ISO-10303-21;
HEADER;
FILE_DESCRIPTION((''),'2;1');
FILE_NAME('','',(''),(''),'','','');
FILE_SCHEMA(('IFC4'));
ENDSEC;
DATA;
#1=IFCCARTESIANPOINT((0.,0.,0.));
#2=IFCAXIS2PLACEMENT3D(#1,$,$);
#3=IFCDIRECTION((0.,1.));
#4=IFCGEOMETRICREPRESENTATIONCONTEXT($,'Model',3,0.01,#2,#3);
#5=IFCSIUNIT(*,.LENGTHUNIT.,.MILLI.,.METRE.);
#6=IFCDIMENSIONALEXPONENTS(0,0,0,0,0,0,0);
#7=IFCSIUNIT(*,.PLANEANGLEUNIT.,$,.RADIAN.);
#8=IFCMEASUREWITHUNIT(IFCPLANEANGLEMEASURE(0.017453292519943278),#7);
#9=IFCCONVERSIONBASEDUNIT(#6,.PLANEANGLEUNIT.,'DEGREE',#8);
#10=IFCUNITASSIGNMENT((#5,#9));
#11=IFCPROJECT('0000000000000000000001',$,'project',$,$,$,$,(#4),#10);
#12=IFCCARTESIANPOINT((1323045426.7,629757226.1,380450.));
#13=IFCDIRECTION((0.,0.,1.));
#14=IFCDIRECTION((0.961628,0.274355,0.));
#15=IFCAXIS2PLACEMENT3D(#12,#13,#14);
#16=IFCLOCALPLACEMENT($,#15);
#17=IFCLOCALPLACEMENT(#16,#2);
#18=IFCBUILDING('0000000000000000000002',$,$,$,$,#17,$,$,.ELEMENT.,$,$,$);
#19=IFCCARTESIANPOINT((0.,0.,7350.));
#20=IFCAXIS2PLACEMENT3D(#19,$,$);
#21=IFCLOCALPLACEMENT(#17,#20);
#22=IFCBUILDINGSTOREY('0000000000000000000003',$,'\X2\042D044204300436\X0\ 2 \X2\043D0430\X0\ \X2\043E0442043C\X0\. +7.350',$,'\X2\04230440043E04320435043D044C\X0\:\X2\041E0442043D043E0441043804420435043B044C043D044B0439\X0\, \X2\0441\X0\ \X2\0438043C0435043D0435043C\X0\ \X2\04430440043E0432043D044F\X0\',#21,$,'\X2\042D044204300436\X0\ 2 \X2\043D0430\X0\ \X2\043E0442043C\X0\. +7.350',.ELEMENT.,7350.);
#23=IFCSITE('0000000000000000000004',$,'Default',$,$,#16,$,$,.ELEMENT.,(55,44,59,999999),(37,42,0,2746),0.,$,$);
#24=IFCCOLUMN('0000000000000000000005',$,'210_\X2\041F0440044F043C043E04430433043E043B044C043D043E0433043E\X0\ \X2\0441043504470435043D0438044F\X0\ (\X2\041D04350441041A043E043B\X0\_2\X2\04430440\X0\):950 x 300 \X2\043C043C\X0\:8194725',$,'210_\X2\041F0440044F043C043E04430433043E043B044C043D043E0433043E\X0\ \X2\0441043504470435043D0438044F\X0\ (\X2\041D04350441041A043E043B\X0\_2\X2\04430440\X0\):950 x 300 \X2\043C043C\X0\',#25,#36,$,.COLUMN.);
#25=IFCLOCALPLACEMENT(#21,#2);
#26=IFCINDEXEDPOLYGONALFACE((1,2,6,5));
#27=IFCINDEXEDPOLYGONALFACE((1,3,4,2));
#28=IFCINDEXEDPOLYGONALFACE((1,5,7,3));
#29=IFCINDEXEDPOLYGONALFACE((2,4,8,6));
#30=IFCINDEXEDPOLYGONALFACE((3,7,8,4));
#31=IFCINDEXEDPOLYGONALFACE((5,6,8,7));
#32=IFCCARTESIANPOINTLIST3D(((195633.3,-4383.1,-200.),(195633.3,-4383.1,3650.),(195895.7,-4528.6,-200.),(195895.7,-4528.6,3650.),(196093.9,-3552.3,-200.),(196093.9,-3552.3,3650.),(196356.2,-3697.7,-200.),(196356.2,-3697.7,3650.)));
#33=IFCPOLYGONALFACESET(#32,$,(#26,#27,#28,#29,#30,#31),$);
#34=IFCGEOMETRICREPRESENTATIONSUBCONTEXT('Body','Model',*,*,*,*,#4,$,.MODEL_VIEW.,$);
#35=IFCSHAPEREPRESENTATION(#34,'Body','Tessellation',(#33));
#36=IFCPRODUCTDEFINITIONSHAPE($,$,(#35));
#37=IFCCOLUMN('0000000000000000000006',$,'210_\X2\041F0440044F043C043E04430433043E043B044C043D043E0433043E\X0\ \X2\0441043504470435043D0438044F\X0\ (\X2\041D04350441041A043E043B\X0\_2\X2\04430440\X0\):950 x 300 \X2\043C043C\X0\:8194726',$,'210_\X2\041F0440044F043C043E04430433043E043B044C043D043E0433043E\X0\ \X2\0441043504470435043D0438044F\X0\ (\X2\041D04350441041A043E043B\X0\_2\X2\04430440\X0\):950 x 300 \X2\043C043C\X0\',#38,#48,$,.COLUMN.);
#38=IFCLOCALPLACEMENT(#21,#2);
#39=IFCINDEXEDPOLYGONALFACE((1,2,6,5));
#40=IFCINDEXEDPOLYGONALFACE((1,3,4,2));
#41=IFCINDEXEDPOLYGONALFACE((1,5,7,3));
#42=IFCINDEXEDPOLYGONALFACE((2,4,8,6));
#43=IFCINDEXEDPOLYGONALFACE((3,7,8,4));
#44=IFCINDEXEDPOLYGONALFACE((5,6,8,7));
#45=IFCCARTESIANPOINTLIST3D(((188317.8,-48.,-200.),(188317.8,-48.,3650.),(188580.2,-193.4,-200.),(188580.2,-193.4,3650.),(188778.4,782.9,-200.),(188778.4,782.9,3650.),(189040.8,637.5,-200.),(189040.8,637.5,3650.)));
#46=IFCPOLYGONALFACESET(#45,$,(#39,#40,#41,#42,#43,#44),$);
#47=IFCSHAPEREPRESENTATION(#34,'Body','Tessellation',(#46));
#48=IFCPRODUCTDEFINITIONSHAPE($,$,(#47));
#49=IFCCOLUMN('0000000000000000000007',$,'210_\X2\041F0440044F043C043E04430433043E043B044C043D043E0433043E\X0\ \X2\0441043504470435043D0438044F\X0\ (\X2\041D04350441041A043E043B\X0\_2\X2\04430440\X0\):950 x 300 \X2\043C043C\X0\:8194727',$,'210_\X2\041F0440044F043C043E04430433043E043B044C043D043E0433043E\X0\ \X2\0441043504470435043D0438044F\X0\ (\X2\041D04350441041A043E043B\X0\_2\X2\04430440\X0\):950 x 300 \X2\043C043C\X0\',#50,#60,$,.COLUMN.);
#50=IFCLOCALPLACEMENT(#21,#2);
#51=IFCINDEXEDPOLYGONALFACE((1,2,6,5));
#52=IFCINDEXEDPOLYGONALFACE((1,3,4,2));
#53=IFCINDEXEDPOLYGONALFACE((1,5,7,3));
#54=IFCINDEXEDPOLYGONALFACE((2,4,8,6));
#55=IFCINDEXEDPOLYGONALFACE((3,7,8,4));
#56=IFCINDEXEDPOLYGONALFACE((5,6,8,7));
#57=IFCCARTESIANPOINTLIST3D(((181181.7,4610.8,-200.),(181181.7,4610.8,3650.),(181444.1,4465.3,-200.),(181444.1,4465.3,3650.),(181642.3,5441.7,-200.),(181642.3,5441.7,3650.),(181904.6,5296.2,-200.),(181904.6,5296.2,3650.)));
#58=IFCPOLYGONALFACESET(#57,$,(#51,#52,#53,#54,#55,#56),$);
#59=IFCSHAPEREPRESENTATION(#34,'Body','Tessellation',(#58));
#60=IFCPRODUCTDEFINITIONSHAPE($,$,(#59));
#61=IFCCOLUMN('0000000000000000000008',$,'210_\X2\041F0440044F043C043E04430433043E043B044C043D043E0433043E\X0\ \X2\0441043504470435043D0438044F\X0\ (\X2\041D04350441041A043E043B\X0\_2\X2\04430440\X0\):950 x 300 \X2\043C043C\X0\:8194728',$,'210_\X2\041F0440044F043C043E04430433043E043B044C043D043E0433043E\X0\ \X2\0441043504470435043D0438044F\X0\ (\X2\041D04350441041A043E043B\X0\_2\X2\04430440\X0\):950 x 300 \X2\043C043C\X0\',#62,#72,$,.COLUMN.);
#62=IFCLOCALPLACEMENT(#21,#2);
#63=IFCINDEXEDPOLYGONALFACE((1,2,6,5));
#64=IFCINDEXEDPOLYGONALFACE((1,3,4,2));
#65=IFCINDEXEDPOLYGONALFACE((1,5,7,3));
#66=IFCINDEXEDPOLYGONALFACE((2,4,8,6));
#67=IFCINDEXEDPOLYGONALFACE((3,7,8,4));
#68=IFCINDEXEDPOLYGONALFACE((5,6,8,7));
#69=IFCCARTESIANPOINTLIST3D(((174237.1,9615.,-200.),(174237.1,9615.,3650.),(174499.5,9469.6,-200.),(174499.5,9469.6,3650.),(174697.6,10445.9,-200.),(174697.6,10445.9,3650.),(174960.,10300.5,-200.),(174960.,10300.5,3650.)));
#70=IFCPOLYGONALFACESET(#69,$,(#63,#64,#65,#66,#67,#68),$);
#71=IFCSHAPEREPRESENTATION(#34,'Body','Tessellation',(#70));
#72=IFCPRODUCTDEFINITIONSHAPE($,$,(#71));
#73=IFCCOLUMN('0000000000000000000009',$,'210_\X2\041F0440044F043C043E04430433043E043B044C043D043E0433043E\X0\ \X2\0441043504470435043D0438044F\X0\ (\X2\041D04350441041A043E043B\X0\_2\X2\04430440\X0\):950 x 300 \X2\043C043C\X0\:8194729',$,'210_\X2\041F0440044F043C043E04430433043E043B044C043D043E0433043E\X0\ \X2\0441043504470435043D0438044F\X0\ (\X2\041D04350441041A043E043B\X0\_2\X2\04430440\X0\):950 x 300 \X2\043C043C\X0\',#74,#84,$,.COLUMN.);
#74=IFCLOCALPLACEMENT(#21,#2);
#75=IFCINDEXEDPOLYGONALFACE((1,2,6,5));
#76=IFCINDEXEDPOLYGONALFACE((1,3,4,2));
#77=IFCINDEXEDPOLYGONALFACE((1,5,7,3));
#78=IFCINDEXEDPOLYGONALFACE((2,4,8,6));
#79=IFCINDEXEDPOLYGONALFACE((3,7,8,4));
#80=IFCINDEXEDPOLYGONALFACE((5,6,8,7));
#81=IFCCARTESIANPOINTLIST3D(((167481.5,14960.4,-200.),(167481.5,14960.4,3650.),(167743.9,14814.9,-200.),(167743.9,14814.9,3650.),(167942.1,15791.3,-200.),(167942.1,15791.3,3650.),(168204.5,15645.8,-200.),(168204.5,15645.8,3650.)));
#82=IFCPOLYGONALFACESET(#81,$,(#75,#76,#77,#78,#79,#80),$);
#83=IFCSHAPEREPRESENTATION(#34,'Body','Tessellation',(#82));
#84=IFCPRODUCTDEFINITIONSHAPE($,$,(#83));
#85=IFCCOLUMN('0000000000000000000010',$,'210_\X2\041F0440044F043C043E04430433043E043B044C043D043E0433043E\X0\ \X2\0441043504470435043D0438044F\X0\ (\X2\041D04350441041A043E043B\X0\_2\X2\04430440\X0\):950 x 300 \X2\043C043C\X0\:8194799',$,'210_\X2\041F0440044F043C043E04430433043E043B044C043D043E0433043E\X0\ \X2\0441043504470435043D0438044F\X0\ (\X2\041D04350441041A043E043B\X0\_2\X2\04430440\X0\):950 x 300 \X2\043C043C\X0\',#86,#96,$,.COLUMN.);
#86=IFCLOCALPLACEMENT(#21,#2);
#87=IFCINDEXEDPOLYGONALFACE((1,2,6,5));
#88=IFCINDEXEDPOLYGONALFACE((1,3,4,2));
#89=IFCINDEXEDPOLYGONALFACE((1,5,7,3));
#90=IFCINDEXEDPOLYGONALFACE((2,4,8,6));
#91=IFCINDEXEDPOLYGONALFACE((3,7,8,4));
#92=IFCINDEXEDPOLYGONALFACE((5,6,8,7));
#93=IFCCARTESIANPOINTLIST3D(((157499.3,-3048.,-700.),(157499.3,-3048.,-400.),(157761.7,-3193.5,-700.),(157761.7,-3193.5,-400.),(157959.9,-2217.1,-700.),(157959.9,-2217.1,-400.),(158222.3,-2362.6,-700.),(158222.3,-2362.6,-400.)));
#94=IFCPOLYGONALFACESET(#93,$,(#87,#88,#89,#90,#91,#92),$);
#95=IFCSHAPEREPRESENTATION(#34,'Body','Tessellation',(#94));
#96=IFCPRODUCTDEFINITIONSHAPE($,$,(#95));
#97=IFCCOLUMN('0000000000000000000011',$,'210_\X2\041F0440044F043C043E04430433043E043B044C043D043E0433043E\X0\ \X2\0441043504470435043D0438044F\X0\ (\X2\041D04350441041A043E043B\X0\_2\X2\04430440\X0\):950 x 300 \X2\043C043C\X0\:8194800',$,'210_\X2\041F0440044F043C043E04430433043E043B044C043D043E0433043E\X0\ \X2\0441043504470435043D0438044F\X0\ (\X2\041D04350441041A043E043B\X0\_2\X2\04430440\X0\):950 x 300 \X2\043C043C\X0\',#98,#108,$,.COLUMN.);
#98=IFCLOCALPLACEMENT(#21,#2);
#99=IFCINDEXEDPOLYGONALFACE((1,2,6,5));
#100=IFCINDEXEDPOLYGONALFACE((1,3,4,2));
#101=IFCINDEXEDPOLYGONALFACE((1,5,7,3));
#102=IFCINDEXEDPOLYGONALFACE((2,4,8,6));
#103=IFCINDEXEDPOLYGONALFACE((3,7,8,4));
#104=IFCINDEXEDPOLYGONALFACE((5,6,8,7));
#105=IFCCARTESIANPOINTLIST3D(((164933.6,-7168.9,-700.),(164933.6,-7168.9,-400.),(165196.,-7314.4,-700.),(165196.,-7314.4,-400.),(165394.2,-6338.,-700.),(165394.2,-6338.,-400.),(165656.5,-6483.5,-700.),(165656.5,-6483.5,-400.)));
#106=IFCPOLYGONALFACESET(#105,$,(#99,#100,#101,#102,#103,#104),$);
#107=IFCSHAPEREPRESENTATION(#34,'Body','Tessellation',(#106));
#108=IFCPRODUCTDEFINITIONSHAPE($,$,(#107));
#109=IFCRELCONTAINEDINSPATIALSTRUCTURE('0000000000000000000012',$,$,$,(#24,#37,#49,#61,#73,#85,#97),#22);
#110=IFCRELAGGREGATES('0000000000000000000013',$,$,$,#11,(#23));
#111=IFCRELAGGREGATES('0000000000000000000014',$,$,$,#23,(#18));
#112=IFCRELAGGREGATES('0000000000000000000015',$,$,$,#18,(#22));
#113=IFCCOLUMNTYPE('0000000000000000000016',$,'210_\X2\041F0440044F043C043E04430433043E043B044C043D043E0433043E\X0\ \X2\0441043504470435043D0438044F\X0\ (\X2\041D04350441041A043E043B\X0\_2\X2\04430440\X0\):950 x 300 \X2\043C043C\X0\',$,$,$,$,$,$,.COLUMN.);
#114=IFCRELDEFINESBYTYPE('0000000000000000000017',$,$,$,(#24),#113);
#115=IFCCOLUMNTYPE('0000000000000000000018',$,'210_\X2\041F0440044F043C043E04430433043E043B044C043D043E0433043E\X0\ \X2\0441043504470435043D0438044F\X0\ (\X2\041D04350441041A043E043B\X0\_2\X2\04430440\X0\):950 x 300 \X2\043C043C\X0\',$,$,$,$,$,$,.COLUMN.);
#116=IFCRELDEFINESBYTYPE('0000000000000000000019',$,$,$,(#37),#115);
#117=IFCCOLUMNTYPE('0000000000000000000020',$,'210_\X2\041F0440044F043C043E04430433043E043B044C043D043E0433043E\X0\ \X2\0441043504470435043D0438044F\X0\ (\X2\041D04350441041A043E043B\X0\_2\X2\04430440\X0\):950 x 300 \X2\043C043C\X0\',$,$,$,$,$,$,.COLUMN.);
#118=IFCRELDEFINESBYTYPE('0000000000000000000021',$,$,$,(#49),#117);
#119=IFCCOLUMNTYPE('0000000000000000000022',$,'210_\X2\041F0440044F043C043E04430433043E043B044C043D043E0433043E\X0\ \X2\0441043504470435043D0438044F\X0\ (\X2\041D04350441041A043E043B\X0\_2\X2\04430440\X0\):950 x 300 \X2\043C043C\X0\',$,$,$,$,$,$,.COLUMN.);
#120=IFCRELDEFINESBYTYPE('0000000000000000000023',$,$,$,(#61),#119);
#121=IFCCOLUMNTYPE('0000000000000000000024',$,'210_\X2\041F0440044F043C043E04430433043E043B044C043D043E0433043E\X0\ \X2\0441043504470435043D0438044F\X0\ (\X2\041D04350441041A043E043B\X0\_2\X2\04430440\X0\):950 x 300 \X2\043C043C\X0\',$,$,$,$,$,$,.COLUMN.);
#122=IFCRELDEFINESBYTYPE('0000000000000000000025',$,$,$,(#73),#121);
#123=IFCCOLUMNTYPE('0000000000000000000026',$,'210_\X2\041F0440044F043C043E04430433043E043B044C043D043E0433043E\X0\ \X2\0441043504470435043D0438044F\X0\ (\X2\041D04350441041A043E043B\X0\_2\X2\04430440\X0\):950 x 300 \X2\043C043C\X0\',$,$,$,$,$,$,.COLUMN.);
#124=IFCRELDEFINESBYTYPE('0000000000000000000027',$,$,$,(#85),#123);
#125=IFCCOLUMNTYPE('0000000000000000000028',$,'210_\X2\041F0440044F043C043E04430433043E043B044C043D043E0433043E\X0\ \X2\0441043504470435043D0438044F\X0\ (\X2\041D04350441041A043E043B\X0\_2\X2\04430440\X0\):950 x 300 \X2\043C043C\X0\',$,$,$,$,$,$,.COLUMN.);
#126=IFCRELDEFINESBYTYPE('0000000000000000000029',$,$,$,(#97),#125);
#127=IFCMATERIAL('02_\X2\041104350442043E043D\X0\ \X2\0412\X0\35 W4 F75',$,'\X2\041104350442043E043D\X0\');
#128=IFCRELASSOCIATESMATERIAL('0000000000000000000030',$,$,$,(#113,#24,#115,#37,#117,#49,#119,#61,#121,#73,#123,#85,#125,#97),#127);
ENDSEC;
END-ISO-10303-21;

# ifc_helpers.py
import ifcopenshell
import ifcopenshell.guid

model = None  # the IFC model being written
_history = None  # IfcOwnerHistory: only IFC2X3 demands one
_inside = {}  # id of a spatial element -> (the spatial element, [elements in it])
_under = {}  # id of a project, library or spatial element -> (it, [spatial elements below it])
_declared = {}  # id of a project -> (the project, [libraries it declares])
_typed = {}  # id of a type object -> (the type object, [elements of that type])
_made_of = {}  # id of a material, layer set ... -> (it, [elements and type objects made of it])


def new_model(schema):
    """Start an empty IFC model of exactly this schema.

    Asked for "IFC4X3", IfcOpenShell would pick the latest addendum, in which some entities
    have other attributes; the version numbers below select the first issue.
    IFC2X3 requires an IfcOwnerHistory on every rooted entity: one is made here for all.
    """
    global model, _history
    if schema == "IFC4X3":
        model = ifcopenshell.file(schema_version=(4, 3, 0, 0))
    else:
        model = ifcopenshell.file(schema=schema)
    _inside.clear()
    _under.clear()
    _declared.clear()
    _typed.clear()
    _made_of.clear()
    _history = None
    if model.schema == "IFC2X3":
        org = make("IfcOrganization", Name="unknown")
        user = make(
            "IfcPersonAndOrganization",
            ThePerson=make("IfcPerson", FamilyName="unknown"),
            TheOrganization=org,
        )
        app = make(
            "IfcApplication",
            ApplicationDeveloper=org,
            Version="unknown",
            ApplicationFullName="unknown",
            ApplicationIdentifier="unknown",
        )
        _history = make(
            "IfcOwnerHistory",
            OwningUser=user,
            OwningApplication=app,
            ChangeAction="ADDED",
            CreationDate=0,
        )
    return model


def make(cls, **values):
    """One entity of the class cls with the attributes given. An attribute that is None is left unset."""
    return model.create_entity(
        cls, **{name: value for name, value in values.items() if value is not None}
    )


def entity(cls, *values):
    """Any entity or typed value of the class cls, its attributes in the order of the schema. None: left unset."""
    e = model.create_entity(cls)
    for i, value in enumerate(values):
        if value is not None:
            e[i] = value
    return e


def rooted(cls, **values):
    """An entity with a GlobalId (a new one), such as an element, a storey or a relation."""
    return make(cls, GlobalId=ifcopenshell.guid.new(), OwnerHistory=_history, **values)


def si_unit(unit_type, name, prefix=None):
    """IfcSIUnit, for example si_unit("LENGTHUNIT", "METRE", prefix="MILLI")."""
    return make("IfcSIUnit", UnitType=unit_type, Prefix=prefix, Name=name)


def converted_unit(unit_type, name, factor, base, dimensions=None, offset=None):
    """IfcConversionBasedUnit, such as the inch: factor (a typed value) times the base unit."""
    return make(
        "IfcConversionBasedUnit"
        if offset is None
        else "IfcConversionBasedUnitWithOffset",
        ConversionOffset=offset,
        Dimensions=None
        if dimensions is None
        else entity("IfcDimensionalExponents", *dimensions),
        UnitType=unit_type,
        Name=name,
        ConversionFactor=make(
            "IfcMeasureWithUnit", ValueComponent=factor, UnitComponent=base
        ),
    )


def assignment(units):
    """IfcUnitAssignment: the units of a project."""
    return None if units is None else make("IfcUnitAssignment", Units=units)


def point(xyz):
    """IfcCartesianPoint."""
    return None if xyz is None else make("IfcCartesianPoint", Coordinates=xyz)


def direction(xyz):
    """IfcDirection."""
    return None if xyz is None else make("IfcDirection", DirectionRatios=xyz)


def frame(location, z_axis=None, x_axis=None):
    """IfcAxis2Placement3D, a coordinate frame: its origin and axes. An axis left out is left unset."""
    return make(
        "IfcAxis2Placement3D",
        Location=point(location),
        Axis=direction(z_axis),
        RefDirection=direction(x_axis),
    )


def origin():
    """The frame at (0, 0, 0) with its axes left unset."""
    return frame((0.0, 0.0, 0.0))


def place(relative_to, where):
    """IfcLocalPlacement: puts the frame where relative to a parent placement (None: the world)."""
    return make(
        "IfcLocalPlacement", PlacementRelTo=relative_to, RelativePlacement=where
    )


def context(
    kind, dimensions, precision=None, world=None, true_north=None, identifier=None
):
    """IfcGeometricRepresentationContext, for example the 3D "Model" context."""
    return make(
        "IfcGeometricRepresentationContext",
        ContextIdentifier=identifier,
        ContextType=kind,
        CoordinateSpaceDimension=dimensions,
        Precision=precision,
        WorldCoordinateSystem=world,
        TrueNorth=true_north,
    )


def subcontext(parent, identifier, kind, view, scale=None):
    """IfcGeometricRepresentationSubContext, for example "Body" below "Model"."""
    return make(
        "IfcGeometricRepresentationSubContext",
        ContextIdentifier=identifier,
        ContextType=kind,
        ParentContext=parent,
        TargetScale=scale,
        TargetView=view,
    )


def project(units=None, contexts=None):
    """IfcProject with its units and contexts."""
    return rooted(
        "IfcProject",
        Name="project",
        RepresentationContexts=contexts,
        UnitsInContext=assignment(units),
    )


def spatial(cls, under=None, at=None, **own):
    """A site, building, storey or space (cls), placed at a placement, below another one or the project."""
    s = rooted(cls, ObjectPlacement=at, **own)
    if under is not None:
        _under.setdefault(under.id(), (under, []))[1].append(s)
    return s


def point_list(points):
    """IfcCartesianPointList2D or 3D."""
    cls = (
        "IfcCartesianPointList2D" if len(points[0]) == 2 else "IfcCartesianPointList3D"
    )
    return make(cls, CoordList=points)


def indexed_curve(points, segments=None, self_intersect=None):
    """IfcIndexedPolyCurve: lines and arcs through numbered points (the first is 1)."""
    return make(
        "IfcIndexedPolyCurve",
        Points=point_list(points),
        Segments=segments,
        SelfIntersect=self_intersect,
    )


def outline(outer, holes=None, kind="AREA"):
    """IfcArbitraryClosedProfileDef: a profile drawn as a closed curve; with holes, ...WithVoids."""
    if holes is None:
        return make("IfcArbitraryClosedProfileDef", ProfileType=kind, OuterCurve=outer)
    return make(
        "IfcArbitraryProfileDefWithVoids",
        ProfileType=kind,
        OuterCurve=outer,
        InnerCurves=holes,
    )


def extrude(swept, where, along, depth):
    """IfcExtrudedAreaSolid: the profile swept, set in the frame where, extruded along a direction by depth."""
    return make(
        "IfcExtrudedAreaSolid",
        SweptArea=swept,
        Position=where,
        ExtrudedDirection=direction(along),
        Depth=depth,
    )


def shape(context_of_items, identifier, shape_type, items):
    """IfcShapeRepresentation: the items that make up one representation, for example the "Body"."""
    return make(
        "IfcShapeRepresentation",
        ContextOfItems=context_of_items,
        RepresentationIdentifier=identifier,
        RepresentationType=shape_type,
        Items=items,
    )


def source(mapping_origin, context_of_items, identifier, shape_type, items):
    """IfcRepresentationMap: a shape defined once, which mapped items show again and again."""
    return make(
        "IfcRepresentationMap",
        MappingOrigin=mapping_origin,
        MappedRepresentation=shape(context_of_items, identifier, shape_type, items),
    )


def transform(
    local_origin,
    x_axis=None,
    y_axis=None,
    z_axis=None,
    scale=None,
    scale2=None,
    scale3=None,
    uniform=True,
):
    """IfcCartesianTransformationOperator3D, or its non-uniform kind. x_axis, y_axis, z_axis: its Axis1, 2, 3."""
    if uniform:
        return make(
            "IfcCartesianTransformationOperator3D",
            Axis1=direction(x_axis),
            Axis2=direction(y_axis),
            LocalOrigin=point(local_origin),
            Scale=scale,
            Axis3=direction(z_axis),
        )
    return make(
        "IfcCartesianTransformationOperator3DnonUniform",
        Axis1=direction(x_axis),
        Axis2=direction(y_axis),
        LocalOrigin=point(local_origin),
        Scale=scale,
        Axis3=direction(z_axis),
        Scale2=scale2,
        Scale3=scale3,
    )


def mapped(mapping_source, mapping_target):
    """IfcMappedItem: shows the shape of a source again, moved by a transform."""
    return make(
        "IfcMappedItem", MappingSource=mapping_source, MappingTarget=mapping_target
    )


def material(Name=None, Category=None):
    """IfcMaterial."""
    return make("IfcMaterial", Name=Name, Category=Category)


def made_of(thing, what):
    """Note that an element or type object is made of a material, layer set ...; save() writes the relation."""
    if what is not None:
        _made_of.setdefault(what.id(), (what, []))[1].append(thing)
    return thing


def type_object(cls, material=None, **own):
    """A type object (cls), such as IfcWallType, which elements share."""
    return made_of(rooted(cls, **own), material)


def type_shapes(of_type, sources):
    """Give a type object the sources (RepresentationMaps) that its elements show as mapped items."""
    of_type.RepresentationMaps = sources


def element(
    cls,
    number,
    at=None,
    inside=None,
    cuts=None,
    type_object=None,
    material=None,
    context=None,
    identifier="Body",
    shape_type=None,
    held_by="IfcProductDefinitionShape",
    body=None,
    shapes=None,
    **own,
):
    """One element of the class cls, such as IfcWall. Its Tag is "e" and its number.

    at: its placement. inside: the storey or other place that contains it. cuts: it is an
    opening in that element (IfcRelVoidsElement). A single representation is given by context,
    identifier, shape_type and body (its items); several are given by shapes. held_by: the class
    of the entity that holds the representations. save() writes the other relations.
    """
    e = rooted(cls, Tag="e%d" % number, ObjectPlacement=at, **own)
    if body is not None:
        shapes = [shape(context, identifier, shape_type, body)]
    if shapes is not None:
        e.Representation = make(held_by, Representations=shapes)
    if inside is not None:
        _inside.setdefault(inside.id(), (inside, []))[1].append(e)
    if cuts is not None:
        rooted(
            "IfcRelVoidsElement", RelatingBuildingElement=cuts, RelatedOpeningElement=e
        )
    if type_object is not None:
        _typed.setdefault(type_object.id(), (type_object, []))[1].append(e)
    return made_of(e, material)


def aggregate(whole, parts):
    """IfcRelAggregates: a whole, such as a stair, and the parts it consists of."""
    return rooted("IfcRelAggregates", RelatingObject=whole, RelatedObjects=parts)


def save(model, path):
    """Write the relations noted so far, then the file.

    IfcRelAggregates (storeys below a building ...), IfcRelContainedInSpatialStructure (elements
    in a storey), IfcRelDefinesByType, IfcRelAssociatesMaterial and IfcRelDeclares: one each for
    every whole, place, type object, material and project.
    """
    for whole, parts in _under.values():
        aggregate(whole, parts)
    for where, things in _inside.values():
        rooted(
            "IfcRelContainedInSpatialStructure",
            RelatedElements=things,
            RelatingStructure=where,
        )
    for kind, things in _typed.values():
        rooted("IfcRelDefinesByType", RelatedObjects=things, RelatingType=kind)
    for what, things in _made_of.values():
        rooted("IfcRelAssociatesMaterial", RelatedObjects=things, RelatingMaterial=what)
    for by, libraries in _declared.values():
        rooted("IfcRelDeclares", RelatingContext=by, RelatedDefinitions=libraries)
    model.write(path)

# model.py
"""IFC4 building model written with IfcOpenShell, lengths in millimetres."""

from ifc_helpers import new_model, entity, si_unit, converted_unit, direction, frame, origin, place, context, subcontext, project, spatial, indexed_curve, outline, extrude, source, transform, mapped, material, type_object, type_shapes, element, save


model = new_model("IFC4")

# Units and contexts
model_context = context("Model", 3, precision=0.01, world=origin(), true_north=direction((0.0, 1.0)))
body_context = subcontext(model_context, "Body", "Model", "MODEL_VIEW")
ifc_project = project(units=[si_unit("LENGTHUNIT", "METRE", prefix="MILLI"), converted_unit("PLANEANGLEUNIT", "DEGREE", entity("IfcPlaneAngleMeasure", 0.017453292519943278), si_unit("PLANEANGLEUNIT", "RADIAN"), dimensions=[0, 0, 0, 0, 0, 0, 0])], contexts=[model_context])

# Site, building, storey
site_placement = place(None, frame((1323045426.7, 629757226.1, 380450.0), z_axis=(0.0, 0.0, 1.0), x_axis=(0.961628, 0.274355, 0.0)))
site = spatial("IfcSite", under=ifc_project, at=site_placement, Name="Default", CompositionType="ELEMENT", RefLatitude=(55, 44, 59, 999999), RefLongitude=(37, 42, 0, 2746), RefElevation=0.0)
building_placement = place(site_placement, origin())
building = spatial("IfcBuilding", under=site, at=building_placement, CompositionType="ELEMENT")
storey_placement = place(building_placement, frame((0.0, 0.0, 7350.0)))
storey = spatial("IfcBuildingStorey", under=building, at=storey_placement, Name="Этаж 2 на отм. +7.350", ObjectType="Уровень:Относительный, с именем уровня", LongName="Этаж 2 на отм. +7.350", CompositionType="ELEMENT", Elevation=7350.0)

# Columns
ifc_material_1 = material(Name="02_Бетон В35 W4 F75", Category="Бетон")
column_type_1 = type_object("IfcColumnType", Name="210_Прямоугольного сечения (НесКол_2ур):950 x 300 мм", PredefinedType="COLUMN", material=ifc_material_1)
shared_shape_1 = source(origin(), body_context, "Body", "SweptSolid", [
    extrude(outline(indexed_curve([(-150.0, -475.0), (150.0, -475.0), (150.0, 475.0), (-150.0, 475.0), (-150.0, -475.0)], self_intersect=False)), frame((195994.8, -4040.4, 7150.0), z_axis=(0.0, 0.0, 1.0), x_axis=(-0.87462, 0.48481, 0.0)), (0.0, 0.0, 1.0), 3850.0),
])
type_shapes(column_type_1, [shared_shape_1])
column_1_placement = place(storey_placement, frame((0.0, 0.0, -7350.0)))
element("IfcColumn", 1, at=column_1_placement, inside=storey, type_object=column_type_1, material=ifc_material_1, Name="210_Прямоугольного сечения (НесКол_2ур):950 x 300 мм:8194725", ObjectType="210_Прямоугольного сечения (НесКол_2ур):950 x 300 мм", PredefinedType="COLUMN", context=body_context, shape_type="MappedRepresentation", body=[
    mapped(shared_shape_1, transform((0.0, 0.0, 0.0), scale=1.0)),
])
column_type_2 = type_object("IfcColumnType", Name="210_Прямоугольного сечения (НесКол_2ур):950 x 300 мм", PredefinedType="COLUMN", material=ifc_material_1)
shared_shape_2 = source(origin(), body_context, "Body", "SweptSolid", [
    extrude(outline(indexed_curve([(-150.0, -475.0), (150.0, -475.0), (150.0, 475.0), (-150.0, 475.0), (-150.0, -475.0)], self_intersect=False)), frame((188679.3, 294.7, 7150.0), z_axis=(0.0, 0.0, 1.0), x_axis=(-0.87462, 0.48481, 0.0)), (0.0, 0.0, 1.0), 3850.0),
])
type_shapes(column_type_2, [shared_shape_2])
column_2_placement = place(storey_placement, frame((0.0, 0.0, -7350.0)))
element("IfcColumn", 2, at=column_2_placement, inside=storey, type_object=column_type_2, material=ifc_material_1, Name="210_Прямоугольного сечения (НесКол_2ур):950 x 300 мм:8194726", ObjectType="210_Прямоугольного сечения (НесКол_2ур):950 x 300 мм", PredefinedType="COLUMN", context=body_context, shape_type="MappedRepresentation", body=[
    mapped(shared_shape_2, transform((0.0, 0.0, 0.0), scale=1.0)),
])
column_type_3 = type_object("IfcColumnType", Name="210_Прямоугольного сечения (НесКол_2ур):950 x 300 мм", PredefinedType="COLUMN", material=ifc_material_1)
shared_shape_3 = source(origin(), body_context, "Body", "SweptSolid", [
    extrude(outline(indexed_curve([(-150.0, -475.0), (150.0, -475.0), (150.0, 475.0), (-150.0, 475.0), (-150.0, -475.0)], self_intersect=False)), frame((181543.2, 4953.5, 7150.0), z_axis=(0.0, 0.0, 1.0), x_axis=(-0.87462, 0.48481, 0.0)), (0.0, 0.0, 1.0), 3850.0),
])
type_shapes(column_type_3, [shared_shape_3])
column_3_placement = place(storey_placement, frame((0.0, 0.0, -7350.0)))
element("IfcColumn", 3, at=column_3_placement, inside=storey, type_object=column_type_3, material=ifc_material_1, Name="210_Прямоугольного сечения (НесКол_2ур):950 x 300 мм:8194727", ObjectType="210_Прямоугольного сечения (НесКол_2ур):950 x 300 мм", PredefinedType="COLUMN", context=body_context, shape_type="MappedRepresentation", body=[
    mapped(shared_shape_3, transform((0.0, 0.0, 0.0), scale=1.0)),
])
column_type_4 = type_object("IfcColumnType", Name="210_Прямоугольного сечения (НесКол_2ур):950 x 300 мм", PredefinedType="COLUMN", material=ifc_material_1)
shared_shape_4 = source(origin(), body_context, "Body", "SweptSolid", [
    extrude(outline(indexed_curve([(-150.0, -475.0), (150.0, -475.0), (150.0, 475.0), (-150.0, 475.0), (-150.0, -475.0)], self_intersect=False)), frame((174598.6, 9957.8, 7150.0), z_axis=(0.0, 0.0, 1.0), x_axis=(-0.87462, 0.48481, 0.0)), (0.0, 0.0, 1.0), 3850.0),
])
type_shapes(column_type_4, [shared_shape_4])
column_4_placement = place(storey_placement, frame((0.0, 0.0, -7350.0)))
element("IfcColumn", 4, at=column_4_placement, inside=storey, type_object=column_type_4, material=ifc_material_1, Name="210_Прямоугольного сечения (НесКол_2ур):950 x 300 мм:8194728", ObjectType="210_Прямоугольного сечения (НесКол_2ур):950 x 300 мм", PredefinedType="COLUMN", context=body_context, shape_type="MappedRepresentation", body=[
    mapped(shared_shape_4, transform((0.0, 0.0, 0.0), scale=1.0)),
])
column_type_5 = type_object("IfcColumnType", Name="210_Прямоугольного сечения (НесКол_2ур):950 x 300 мм", PredefinedType="COLUMN", material=ifc_material_1)
shared_shape_5 = source(origin(), body_context, "Body", "SweptSolid", [
    extrude(outline(indexed_curve([(-150.0, -475.0), (150.0, -475.0), (150.0, 475.0), (-150.0, 475.0), (-150.0, -475.0)], self_intersect=False)), frame((167843.0, 15303.1, 7150.0), z_axis=(0.0, 0.0, 1.0), x_axis=(-0.87462, 0.48481, 0.0)), (0.0, 0.0, 1.0), 3850.0),
])
type_shapes(column_type_5, [shared_shape_5])
column_5_placement = place(storey_placement, frame((0.0, 0.0, -7350.0)))
element("IfcColumn", 5, at=column_5_placement, inside=storey, type_object=column_type_5, material=ifc_material_1, Name="210_Прямоугольного сечения (НесКол_2ур):950 x 300 мм:8194729", ObjectType="210_Прямоугольного сечения (НесКол_2ур):950 x 300 мм", PredefinedType="COLUMN", context=body_context, shape_type="MappedRepresentation", body=[
    mapped(shared_shape_5, transform((0.0, 0.0, 0.0), scale=1.0)),
])
column_type_6 = type_object("IfcColumnType", Name="210_Прямоугольного сечения (НесКол_2ур):950 x 300 мм", PredefinedType="COLUMN", material=ifc_material_1)
shared_shape_6 = source(origin(), body_context, "Body", "SweptSolid", [
    extrude(outline(indexed_curve([(-150.0, -150.0), (150.0, -150.0), (150.0, 150.0), (-150.0, 150.0), (-150.0, -150.0)], self_intersect=False)), frame((157630.5, -3120.8, 6800.0), z_axis=(0.48481, 0.87462, 0.0), x_axis=(0.0, 0.0, 1.0)), (0.0, 0.0, 1.0), 950.0),
])
type_shapes(column_type_6, [shared_shape_6])
column_6_placement = place(storey_placement, frame((0.0, 0.0, -7350.0)))
element("IfcColumn", 6, at=column_6_placement, inside=storey, type_object=column_type_6, material=ifc_material_1, Name="210_Прямоугольного сечения (НесКол_2ур):950 x 300 мм:8194799", ObjectType="210_Прямоугольного сечения (НесКол_2ур):950 x 300 мм", PredefinedType="COLUMN", context=body_context, shape_type="MappedRepresentation", body=[
    mapped(shared_shape_6, transform((0.0, 0.0, 0.0), scale=1.0)),
])
column_type_7 = type_object("IfcColumnType", Name="210_Прямоугольного сечения (НесКол_2ур):950 x 300 мм", PredefinedType="COLUMN", material=ifc_material_1)
shared_shape_7 = source(origin(), body_context, "Body", "SweptSolid", [
    extrude(outline(indexed_curve([(-150.0, -150.0), (150.0, -150.0), (150.0, 150.0), (-150.0, 150.0), (-150.0, -150.0)], self_intersect=False)), frame((165064.8, -7241.6, 6800.0), z_axis=(0.48481, 0.87462, 0.0), x_axis=(0.0, 0.0, 1.0)), (0.0, 0.0, 1.0), 950.0),
])
type_shapes(column_type_7, [shared_shape_7])
column_7_placement = place(storey_placement, frame((0.0, 0.0, -7350.0)))
element("IfcColumn", 7, at=column_7_placement, inside=storey, type_object=column_type_7, material=ifc_material_1, Name="210_Прямоугольного сечения (НесКол_2ур):950 x 300 мм:8194800", ObjectType="210_Прямоугольного сечения (НесКол_2ур):950 x 300 мм", PredefinedType="COLUMN", context=body_context, shape_type="MappedRepresentation", body=[
    mapped(shared_shape_7, transform((0.0, 0.0, 0.0), scale=1.0)),
])

save(model, "model.ifc")
